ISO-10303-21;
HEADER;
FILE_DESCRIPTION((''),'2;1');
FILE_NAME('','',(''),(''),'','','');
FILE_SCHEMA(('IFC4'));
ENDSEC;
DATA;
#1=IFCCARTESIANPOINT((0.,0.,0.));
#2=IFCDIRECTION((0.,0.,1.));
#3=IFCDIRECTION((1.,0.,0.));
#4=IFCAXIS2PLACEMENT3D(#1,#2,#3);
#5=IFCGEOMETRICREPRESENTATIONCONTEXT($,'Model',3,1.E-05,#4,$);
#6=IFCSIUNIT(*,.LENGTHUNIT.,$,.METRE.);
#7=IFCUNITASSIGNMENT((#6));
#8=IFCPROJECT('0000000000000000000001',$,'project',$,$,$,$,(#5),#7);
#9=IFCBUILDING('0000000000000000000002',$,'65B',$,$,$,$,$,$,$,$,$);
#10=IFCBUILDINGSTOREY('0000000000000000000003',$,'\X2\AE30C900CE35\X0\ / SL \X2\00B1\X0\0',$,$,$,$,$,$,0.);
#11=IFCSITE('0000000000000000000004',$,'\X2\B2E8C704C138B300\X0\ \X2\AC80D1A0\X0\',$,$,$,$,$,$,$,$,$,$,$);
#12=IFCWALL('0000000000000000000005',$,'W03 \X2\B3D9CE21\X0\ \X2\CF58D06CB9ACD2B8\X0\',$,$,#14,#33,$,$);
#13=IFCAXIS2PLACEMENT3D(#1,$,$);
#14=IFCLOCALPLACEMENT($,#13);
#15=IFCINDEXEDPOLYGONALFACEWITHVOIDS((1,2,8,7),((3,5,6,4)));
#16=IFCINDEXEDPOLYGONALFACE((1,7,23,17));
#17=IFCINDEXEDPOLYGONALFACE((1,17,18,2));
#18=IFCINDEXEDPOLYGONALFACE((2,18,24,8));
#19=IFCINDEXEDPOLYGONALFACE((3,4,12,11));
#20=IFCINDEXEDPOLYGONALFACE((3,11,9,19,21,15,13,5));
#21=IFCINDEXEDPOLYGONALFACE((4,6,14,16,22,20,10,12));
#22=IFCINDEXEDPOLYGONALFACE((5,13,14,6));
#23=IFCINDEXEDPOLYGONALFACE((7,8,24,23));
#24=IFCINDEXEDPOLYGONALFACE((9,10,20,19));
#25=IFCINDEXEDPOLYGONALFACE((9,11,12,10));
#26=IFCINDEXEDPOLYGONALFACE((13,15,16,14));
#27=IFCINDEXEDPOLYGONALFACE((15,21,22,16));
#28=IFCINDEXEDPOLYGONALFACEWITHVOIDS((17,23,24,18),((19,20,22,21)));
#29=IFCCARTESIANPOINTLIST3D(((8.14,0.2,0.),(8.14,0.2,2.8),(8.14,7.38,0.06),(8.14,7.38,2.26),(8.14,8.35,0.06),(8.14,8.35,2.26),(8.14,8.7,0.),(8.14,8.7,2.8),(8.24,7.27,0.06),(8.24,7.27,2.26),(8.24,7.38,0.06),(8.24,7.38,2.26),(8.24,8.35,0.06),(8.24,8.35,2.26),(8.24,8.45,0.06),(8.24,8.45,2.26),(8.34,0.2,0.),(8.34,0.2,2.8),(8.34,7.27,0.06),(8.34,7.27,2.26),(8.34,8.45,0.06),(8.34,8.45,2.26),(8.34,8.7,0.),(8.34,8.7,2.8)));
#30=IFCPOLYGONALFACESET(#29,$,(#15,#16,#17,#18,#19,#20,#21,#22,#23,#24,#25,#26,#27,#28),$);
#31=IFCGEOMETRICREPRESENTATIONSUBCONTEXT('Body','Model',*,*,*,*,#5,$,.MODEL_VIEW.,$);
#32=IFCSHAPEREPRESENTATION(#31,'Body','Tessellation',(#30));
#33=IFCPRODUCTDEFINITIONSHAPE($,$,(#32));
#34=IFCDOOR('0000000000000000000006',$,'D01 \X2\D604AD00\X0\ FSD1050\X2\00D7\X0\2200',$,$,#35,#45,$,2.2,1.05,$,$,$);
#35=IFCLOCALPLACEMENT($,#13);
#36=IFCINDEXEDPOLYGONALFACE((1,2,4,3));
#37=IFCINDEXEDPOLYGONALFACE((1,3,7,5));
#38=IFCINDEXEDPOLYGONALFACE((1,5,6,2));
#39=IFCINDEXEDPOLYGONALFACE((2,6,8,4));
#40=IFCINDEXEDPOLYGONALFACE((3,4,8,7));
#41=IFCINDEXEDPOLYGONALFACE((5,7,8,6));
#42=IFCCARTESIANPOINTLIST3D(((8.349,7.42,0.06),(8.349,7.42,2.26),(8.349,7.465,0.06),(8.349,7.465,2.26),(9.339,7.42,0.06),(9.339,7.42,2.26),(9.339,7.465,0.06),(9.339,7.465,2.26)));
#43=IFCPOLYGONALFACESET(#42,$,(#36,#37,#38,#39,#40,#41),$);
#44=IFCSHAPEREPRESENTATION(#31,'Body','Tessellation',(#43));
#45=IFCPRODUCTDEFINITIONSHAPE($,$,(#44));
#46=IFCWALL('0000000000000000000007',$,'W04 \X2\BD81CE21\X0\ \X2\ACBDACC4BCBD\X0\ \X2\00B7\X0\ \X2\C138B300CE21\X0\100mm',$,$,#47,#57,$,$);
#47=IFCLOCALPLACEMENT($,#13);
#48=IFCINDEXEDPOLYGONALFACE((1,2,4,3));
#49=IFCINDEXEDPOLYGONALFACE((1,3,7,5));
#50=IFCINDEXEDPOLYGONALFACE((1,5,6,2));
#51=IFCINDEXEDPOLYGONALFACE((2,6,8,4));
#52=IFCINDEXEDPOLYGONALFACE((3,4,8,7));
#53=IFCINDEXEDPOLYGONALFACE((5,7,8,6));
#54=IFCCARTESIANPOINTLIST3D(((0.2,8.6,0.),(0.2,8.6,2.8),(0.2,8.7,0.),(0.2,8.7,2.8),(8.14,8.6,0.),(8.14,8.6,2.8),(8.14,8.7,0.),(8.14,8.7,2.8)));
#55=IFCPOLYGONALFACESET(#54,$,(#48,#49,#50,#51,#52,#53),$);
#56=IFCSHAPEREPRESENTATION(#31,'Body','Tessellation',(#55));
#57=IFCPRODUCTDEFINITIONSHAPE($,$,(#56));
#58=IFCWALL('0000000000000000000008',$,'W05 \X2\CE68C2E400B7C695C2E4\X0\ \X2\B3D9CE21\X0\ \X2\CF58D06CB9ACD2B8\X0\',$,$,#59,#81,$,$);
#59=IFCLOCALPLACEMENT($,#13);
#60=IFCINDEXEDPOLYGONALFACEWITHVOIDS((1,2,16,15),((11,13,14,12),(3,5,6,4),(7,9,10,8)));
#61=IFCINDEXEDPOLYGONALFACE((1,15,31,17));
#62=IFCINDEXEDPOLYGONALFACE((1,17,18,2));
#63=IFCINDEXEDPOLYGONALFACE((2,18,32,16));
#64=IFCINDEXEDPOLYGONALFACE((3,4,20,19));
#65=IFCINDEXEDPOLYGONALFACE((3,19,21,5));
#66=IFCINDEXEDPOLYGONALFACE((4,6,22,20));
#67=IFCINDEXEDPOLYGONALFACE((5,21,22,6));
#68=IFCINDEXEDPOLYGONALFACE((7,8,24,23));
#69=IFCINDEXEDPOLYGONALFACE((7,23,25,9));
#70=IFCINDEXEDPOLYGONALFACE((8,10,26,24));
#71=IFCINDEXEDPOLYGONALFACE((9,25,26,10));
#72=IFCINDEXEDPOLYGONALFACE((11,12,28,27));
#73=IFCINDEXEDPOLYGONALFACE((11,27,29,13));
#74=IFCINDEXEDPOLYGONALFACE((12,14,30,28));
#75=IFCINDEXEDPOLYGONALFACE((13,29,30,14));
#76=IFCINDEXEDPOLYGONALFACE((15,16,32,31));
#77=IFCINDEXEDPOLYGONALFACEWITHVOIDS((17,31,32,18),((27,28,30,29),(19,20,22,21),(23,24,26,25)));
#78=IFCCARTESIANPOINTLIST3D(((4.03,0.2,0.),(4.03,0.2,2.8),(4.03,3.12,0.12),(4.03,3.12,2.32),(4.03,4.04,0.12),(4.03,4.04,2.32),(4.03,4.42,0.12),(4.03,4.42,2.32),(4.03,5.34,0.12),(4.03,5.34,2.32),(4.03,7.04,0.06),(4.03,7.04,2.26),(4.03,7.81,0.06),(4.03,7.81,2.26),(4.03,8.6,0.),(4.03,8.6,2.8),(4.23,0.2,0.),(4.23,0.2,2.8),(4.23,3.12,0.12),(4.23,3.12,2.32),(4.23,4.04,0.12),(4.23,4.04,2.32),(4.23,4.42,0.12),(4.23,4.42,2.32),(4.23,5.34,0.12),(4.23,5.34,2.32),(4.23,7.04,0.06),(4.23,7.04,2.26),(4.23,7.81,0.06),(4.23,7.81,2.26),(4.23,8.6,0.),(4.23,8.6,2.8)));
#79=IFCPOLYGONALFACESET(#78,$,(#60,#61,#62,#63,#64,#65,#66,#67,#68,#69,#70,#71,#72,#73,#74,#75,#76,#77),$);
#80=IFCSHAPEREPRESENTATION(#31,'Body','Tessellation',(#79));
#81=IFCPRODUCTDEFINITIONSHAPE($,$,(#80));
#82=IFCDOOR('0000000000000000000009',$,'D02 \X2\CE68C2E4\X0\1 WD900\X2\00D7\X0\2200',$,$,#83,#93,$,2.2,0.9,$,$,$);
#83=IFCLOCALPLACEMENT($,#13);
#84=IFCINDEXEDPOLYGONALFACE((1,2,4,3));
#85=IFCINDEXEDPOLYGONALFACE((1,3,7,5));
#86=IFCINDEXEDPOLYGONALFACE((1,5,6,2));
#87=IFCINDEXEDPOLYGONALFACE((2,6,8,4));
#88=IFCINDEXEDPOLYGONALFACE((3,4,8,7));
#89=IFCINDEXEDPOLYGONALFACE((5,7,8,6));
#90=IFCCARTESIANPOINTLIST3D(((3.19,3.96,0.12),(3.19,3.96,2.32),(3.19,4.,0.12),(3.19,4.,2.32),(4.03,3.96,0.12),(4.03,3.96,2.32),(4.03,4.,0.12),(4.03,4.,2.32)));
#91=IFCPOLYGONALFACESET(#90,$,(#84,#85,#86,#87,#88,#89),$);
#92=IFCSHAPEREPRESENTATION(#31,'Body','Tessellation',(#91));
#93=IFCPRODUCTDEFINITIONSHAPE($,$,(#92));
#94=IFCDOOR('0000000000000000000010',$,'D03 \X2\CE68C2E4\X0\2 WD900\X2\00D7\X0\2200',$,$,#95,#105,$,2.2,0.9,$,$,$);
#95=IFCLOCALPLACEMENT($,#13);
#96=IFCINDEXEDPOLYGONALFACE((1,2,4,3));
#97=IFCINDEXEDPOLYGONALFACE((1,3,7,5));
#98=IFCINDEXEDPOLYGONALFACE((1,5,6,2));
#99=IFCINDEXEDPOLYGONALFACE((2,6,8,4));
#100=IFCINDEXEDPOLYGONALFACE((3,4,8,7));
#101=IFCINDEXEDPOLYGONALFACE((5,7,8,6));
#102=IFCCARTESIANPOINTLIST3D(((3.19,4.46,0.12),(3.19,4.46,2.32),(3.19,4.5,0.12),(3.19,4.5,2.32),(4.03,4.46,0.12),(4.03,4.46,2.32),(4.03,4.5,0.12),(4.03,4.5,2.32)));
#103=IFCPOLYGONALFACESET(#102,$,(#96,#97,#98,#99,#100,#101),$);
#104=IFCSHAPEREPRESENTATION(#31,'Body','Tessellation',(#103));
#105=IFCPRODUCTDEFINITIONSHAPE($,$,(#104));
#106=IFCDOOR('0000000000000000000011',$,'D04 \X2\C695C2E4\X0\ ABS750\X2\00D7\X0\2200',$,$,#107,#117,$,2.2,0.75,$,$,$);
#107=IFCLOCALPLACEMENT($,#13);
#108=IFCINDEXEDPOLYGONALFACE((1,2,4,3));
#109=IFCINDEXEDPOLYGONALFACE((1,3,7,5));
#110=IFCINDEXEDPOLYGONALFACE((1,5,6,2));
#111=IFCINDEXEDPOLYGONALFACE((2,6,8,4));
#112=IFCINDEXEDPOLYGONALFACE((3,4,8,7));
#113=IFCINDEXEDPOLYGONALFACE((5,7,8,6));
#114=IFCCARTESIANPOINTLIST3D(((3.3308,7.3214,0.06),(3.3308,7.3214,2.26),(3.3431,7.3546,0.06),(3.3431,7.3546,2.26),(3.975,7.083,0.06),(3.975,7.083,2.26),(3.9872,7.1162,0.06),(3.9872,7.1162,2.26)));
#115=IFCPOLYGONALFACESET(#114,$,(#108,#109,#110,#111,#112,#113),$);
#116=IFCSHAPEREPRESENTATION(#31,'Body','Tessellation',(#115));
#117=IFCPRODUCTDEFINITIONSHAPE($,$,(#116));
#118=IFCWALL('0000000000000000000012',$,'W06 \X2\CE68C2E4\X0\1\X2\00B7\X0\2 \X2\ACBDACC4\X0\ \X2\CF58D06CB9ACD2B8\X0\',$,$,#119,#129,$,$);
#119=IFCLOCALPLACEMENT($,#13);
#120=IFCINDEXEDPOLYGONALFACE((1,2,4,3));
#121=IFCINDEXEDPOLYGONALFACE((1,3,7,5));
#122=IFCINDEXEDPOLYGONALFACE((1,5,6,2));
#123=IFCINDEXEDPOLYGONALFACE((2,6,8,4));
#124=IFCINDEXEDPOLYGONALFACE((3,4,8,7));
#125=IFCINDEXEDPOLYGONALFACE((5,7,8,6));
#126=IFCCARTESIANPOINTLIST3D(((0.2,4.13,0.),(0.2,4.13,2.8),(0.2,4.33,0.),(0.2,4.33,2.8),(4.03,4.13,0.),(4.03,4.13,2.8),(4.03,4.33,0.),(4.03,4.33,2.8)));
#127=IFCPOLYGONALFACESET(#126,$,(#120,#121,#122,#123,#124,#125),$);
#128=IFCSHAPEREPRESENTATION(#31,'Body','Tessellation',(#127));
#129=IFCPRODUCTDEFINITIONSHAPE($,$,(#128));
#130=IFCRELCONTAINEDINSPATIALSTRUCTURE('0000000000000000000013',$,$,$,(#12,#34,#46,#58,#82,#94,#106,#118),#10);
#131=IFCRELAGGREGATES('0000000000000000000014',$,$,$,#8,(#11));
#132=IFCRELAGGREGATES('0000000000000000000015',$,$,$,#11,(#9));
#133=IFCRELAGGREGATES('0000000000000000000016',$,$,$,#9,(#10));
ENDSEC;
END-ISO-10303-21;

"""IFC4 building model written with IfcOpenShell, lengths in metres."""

from ifc_helpers import new_model, si_unit, frame, origin, origin_with_axes, place, context, subcontext, project, spatial, polyline, outline, extrude, element, fill, save


model = new_model("IFC4")

# Units and contexts
model_context = context("Model", 3, precision=1e-05, world=origin_with_axes())
body_context = subcontext(model_context, "Body", "Model", "MODEL_VIEW")
ifc_project = project(units=[si_unit("LENGTHUNIT", "METRE")], contexts=[model_context])

# Site, building, storey
site = spatial("IfcSite", under=ifc_project, Name="단위세대 검토")
building = spatial("IfcBuilding", under=site, Name="65B")
storey = spatial("IfcBuildingStorey", under=building, Name="기준층 / SL ±0", Elevation=0.0)

# Wall, opening, door
wall_1_placement = place(None, origin_with_axes())
wall_1 = element("IfcWall", 1, at=wall_1_placement, inside=storey, Name="W03 동측 콘크리트", context=body_context, shape_type="SweptSolid", body=[
    extrude(outline(polyline([(8.34, 0.2), (8.34, 8.7), (8.14, 8.7), (8.14, 0.2), (8.34, 0.2)])), origin(), (0.0, 0.0, 1.0), 2.8),
])
opening_1_placement = place(wall_1_placement, origin_with_axes())
opening_1 = element("IfcOpeningElement", 2, at=opening_1_placement, cuts=wall_1, context=body_context, shape_type="SweptSolid", body=[
    extrude(outline(polyline([(8.139, 7.38), (8.24, 7.38), (8.24, 7.27), (8.341, 7.27), (8.341, 8.45), (8.24, 8.45), (8.24, 8.35), (8.139, 8.35), (8.139, 7.38)])), frame((0.0, 0.0, 0.06)), (0.0, 0.0, 1.0), 2.2),
])
door_1_placement = place(None, origin_with_axes())
door_1 = element("IfcDoor", 3, at=door_1_placement, inside=storey, Name="D01 현관 FSD1050×2200", OverallHeight=2.2, OverallWidth=1.05, context=body_context, shape_type="SweptSolid", body=[
    extrude(outline(polyline([(8.349, 7.465), (9.339, 7.465), (9.339, 7.42), (8.349, 7.42), (8.349, 7.465)])), frame((0.0, 0.0, 0.06)), (0.0, 0.0, 1.0), 2.2),
])
fill(opening_1, door_1)

# Wall
wall_2_placement = place(None, origin_with_axes())
element("IfcWall", 4, at=wall_2_placement, inside=storey, Name="W04 북측 경계벽 · 세대측100mm", context=body_context, shape_type="SweptSolid", body=[
    extrude(outline(polyline([(8.14, 8.6), (8.14, 8.7), (0.2, 8.7), (0.2, 8.6), (8.14, 8.6)])), origin(), (0.0, 0.0, 1.0), 2.8),
])

# Wall, openings, doors
wall_3_placement = place(None, origin_with_axes())
wall_3 = element("IfcWall", 5, at=wall_3_placement, inside=storey, Name="W05 침실·욕실 동측 콘크리트", context=body_context, shape_type="SweptSolid", body=[
    extrude(outline(polyline([(4.23, 0.2), (4.23, 8.6), (4.03, 8.6), (4.03, 0.2), (4.23, 0.2)])), origin(), (0.0, 0.0, 1.0), 2.8),
])
opening_2_placement = place(wall_3_placement, origin_with_axes())
opening_2 = element("IfcOpeningElement", 6, at=opening_2_placement, cuts=wall_3, context=body_context, shape_type="SweptSolid", body=[
    extrude(outline(polyline([(4.231, 3.12), (4.231, 4.04), (4.029, 4.04), (4.029, 3.12), (4.231, 3.12)])), frame((0.0, 0.0, 0.12)), (0.0, 0.0, 1.0), 2.2),
])
opening_3_placement = place(wall_3_placement, origin_with_axes())
opening_3 = element("IfcOpeningElement", 7, at=opening_3_placement, cuts=wall_3, context=body_context, shape_type="SweptSolid", body=[
    extrude(outline(polyline([(4.231, 4.42), (4.231, 5.34), (4.029, 5.34), (4.029, 4.42), (4.231, 4.42)])), frame((0.0, 0.0, 0.12)), (0.0, 0.0, 1.0), 2.2),
])
opening_4_placement = place(wall_3_placement, origin_with_axes())
opening_4 = element("IfcOpeningElement", 8, at=opening_4_placement, cuts=wall_3, context=body_context, shape_type="SweptSolid", body=[
    extrude(outline(polyline([(4.231, 7.04), (4.231, 7.81), (4.029, 7.81), (4.029, 7.04), (4.231, 7.04)])), frame((0.0, 0.0, 0.06)), (0.0, 0.0, 1.0), 2.2),
])
door_2_placement = place(None, origin_with_axes())
door_2 = element("IfcDoor", 9, at=door_2_placement, inside=storey, Name="D02 침실1 WD900×2200", OverallHeight=2.2, OverallWidth=0.9, context=body_context, shape_type="SweptSolid", body=[
    extrude(outline(polyline([(4.03, 3.96), (4.03, 4.0), (3.19, 4.0), (3.19, 3.96), (4.03, 3.96)])), frame((0.0, 0.0, 0.12)), (0.0, 0.0, 1.0), 2.2),
])
fill(opening_2, door_2)
door_3_placement = place(None, origin_with_axes())
door_3 = element("IfcDoor", 10, at=door_3_placement, inside=storey, Name="D03 침실2 WD900×2200", OverallHeight=2.2, OverallWidth=0.9, context=body_context, shape_type="SweptSolid", body=[
    extrude(outline(polyline([(4.03, 4.5), (4.03, 4.46), (3.19, 4.46), (3.19, 4.5), (4.03, 4.5)])), frame((0.0, 0.0, 0.12)), (0.0, 0.0, 1.0), 2.2),
])
fill(opening_3, door_3)
door_4_placement = place(None, origin_with_axes())
door_4 = element("IfcDoor", 11, at=door_4_placement, inside=storey, Name="D04 욕실 ABS750×2200", OverallHeight=2.2, OverallWidth=0.75, context=body_context, shape_type="SweptSolid", body=[
    extrude(outline(polyline([(3.975, 7.083), (3.3308, 7.3214), (3.3431, 7.3546), (3.9872, 7.1162), (3.975, 7.083)])), frame((0.0, 0.0, 0.06)), (0.0, 0.0, 1.0), 2.2),
])
fill(opening_4, door_4)

# Wall
wall_4_placement = place(None, origin_with_axes())
element("IfcWall", 12, at=wall_4_placement, inside=storey, Name="W06 침실1·2 경계 콘크리트", context=body_context, shape_type="SweptSolid", body=[
    extrude(outline(polyline([(4.03, 4.13), (4.03, 4.33), (0.2, 4.33), (0.2, 4.13), (4.03, 4.13)])), origin(), (0.0, 0.0, 1.0), 2.8),
])

save(model, "model.ifc")
